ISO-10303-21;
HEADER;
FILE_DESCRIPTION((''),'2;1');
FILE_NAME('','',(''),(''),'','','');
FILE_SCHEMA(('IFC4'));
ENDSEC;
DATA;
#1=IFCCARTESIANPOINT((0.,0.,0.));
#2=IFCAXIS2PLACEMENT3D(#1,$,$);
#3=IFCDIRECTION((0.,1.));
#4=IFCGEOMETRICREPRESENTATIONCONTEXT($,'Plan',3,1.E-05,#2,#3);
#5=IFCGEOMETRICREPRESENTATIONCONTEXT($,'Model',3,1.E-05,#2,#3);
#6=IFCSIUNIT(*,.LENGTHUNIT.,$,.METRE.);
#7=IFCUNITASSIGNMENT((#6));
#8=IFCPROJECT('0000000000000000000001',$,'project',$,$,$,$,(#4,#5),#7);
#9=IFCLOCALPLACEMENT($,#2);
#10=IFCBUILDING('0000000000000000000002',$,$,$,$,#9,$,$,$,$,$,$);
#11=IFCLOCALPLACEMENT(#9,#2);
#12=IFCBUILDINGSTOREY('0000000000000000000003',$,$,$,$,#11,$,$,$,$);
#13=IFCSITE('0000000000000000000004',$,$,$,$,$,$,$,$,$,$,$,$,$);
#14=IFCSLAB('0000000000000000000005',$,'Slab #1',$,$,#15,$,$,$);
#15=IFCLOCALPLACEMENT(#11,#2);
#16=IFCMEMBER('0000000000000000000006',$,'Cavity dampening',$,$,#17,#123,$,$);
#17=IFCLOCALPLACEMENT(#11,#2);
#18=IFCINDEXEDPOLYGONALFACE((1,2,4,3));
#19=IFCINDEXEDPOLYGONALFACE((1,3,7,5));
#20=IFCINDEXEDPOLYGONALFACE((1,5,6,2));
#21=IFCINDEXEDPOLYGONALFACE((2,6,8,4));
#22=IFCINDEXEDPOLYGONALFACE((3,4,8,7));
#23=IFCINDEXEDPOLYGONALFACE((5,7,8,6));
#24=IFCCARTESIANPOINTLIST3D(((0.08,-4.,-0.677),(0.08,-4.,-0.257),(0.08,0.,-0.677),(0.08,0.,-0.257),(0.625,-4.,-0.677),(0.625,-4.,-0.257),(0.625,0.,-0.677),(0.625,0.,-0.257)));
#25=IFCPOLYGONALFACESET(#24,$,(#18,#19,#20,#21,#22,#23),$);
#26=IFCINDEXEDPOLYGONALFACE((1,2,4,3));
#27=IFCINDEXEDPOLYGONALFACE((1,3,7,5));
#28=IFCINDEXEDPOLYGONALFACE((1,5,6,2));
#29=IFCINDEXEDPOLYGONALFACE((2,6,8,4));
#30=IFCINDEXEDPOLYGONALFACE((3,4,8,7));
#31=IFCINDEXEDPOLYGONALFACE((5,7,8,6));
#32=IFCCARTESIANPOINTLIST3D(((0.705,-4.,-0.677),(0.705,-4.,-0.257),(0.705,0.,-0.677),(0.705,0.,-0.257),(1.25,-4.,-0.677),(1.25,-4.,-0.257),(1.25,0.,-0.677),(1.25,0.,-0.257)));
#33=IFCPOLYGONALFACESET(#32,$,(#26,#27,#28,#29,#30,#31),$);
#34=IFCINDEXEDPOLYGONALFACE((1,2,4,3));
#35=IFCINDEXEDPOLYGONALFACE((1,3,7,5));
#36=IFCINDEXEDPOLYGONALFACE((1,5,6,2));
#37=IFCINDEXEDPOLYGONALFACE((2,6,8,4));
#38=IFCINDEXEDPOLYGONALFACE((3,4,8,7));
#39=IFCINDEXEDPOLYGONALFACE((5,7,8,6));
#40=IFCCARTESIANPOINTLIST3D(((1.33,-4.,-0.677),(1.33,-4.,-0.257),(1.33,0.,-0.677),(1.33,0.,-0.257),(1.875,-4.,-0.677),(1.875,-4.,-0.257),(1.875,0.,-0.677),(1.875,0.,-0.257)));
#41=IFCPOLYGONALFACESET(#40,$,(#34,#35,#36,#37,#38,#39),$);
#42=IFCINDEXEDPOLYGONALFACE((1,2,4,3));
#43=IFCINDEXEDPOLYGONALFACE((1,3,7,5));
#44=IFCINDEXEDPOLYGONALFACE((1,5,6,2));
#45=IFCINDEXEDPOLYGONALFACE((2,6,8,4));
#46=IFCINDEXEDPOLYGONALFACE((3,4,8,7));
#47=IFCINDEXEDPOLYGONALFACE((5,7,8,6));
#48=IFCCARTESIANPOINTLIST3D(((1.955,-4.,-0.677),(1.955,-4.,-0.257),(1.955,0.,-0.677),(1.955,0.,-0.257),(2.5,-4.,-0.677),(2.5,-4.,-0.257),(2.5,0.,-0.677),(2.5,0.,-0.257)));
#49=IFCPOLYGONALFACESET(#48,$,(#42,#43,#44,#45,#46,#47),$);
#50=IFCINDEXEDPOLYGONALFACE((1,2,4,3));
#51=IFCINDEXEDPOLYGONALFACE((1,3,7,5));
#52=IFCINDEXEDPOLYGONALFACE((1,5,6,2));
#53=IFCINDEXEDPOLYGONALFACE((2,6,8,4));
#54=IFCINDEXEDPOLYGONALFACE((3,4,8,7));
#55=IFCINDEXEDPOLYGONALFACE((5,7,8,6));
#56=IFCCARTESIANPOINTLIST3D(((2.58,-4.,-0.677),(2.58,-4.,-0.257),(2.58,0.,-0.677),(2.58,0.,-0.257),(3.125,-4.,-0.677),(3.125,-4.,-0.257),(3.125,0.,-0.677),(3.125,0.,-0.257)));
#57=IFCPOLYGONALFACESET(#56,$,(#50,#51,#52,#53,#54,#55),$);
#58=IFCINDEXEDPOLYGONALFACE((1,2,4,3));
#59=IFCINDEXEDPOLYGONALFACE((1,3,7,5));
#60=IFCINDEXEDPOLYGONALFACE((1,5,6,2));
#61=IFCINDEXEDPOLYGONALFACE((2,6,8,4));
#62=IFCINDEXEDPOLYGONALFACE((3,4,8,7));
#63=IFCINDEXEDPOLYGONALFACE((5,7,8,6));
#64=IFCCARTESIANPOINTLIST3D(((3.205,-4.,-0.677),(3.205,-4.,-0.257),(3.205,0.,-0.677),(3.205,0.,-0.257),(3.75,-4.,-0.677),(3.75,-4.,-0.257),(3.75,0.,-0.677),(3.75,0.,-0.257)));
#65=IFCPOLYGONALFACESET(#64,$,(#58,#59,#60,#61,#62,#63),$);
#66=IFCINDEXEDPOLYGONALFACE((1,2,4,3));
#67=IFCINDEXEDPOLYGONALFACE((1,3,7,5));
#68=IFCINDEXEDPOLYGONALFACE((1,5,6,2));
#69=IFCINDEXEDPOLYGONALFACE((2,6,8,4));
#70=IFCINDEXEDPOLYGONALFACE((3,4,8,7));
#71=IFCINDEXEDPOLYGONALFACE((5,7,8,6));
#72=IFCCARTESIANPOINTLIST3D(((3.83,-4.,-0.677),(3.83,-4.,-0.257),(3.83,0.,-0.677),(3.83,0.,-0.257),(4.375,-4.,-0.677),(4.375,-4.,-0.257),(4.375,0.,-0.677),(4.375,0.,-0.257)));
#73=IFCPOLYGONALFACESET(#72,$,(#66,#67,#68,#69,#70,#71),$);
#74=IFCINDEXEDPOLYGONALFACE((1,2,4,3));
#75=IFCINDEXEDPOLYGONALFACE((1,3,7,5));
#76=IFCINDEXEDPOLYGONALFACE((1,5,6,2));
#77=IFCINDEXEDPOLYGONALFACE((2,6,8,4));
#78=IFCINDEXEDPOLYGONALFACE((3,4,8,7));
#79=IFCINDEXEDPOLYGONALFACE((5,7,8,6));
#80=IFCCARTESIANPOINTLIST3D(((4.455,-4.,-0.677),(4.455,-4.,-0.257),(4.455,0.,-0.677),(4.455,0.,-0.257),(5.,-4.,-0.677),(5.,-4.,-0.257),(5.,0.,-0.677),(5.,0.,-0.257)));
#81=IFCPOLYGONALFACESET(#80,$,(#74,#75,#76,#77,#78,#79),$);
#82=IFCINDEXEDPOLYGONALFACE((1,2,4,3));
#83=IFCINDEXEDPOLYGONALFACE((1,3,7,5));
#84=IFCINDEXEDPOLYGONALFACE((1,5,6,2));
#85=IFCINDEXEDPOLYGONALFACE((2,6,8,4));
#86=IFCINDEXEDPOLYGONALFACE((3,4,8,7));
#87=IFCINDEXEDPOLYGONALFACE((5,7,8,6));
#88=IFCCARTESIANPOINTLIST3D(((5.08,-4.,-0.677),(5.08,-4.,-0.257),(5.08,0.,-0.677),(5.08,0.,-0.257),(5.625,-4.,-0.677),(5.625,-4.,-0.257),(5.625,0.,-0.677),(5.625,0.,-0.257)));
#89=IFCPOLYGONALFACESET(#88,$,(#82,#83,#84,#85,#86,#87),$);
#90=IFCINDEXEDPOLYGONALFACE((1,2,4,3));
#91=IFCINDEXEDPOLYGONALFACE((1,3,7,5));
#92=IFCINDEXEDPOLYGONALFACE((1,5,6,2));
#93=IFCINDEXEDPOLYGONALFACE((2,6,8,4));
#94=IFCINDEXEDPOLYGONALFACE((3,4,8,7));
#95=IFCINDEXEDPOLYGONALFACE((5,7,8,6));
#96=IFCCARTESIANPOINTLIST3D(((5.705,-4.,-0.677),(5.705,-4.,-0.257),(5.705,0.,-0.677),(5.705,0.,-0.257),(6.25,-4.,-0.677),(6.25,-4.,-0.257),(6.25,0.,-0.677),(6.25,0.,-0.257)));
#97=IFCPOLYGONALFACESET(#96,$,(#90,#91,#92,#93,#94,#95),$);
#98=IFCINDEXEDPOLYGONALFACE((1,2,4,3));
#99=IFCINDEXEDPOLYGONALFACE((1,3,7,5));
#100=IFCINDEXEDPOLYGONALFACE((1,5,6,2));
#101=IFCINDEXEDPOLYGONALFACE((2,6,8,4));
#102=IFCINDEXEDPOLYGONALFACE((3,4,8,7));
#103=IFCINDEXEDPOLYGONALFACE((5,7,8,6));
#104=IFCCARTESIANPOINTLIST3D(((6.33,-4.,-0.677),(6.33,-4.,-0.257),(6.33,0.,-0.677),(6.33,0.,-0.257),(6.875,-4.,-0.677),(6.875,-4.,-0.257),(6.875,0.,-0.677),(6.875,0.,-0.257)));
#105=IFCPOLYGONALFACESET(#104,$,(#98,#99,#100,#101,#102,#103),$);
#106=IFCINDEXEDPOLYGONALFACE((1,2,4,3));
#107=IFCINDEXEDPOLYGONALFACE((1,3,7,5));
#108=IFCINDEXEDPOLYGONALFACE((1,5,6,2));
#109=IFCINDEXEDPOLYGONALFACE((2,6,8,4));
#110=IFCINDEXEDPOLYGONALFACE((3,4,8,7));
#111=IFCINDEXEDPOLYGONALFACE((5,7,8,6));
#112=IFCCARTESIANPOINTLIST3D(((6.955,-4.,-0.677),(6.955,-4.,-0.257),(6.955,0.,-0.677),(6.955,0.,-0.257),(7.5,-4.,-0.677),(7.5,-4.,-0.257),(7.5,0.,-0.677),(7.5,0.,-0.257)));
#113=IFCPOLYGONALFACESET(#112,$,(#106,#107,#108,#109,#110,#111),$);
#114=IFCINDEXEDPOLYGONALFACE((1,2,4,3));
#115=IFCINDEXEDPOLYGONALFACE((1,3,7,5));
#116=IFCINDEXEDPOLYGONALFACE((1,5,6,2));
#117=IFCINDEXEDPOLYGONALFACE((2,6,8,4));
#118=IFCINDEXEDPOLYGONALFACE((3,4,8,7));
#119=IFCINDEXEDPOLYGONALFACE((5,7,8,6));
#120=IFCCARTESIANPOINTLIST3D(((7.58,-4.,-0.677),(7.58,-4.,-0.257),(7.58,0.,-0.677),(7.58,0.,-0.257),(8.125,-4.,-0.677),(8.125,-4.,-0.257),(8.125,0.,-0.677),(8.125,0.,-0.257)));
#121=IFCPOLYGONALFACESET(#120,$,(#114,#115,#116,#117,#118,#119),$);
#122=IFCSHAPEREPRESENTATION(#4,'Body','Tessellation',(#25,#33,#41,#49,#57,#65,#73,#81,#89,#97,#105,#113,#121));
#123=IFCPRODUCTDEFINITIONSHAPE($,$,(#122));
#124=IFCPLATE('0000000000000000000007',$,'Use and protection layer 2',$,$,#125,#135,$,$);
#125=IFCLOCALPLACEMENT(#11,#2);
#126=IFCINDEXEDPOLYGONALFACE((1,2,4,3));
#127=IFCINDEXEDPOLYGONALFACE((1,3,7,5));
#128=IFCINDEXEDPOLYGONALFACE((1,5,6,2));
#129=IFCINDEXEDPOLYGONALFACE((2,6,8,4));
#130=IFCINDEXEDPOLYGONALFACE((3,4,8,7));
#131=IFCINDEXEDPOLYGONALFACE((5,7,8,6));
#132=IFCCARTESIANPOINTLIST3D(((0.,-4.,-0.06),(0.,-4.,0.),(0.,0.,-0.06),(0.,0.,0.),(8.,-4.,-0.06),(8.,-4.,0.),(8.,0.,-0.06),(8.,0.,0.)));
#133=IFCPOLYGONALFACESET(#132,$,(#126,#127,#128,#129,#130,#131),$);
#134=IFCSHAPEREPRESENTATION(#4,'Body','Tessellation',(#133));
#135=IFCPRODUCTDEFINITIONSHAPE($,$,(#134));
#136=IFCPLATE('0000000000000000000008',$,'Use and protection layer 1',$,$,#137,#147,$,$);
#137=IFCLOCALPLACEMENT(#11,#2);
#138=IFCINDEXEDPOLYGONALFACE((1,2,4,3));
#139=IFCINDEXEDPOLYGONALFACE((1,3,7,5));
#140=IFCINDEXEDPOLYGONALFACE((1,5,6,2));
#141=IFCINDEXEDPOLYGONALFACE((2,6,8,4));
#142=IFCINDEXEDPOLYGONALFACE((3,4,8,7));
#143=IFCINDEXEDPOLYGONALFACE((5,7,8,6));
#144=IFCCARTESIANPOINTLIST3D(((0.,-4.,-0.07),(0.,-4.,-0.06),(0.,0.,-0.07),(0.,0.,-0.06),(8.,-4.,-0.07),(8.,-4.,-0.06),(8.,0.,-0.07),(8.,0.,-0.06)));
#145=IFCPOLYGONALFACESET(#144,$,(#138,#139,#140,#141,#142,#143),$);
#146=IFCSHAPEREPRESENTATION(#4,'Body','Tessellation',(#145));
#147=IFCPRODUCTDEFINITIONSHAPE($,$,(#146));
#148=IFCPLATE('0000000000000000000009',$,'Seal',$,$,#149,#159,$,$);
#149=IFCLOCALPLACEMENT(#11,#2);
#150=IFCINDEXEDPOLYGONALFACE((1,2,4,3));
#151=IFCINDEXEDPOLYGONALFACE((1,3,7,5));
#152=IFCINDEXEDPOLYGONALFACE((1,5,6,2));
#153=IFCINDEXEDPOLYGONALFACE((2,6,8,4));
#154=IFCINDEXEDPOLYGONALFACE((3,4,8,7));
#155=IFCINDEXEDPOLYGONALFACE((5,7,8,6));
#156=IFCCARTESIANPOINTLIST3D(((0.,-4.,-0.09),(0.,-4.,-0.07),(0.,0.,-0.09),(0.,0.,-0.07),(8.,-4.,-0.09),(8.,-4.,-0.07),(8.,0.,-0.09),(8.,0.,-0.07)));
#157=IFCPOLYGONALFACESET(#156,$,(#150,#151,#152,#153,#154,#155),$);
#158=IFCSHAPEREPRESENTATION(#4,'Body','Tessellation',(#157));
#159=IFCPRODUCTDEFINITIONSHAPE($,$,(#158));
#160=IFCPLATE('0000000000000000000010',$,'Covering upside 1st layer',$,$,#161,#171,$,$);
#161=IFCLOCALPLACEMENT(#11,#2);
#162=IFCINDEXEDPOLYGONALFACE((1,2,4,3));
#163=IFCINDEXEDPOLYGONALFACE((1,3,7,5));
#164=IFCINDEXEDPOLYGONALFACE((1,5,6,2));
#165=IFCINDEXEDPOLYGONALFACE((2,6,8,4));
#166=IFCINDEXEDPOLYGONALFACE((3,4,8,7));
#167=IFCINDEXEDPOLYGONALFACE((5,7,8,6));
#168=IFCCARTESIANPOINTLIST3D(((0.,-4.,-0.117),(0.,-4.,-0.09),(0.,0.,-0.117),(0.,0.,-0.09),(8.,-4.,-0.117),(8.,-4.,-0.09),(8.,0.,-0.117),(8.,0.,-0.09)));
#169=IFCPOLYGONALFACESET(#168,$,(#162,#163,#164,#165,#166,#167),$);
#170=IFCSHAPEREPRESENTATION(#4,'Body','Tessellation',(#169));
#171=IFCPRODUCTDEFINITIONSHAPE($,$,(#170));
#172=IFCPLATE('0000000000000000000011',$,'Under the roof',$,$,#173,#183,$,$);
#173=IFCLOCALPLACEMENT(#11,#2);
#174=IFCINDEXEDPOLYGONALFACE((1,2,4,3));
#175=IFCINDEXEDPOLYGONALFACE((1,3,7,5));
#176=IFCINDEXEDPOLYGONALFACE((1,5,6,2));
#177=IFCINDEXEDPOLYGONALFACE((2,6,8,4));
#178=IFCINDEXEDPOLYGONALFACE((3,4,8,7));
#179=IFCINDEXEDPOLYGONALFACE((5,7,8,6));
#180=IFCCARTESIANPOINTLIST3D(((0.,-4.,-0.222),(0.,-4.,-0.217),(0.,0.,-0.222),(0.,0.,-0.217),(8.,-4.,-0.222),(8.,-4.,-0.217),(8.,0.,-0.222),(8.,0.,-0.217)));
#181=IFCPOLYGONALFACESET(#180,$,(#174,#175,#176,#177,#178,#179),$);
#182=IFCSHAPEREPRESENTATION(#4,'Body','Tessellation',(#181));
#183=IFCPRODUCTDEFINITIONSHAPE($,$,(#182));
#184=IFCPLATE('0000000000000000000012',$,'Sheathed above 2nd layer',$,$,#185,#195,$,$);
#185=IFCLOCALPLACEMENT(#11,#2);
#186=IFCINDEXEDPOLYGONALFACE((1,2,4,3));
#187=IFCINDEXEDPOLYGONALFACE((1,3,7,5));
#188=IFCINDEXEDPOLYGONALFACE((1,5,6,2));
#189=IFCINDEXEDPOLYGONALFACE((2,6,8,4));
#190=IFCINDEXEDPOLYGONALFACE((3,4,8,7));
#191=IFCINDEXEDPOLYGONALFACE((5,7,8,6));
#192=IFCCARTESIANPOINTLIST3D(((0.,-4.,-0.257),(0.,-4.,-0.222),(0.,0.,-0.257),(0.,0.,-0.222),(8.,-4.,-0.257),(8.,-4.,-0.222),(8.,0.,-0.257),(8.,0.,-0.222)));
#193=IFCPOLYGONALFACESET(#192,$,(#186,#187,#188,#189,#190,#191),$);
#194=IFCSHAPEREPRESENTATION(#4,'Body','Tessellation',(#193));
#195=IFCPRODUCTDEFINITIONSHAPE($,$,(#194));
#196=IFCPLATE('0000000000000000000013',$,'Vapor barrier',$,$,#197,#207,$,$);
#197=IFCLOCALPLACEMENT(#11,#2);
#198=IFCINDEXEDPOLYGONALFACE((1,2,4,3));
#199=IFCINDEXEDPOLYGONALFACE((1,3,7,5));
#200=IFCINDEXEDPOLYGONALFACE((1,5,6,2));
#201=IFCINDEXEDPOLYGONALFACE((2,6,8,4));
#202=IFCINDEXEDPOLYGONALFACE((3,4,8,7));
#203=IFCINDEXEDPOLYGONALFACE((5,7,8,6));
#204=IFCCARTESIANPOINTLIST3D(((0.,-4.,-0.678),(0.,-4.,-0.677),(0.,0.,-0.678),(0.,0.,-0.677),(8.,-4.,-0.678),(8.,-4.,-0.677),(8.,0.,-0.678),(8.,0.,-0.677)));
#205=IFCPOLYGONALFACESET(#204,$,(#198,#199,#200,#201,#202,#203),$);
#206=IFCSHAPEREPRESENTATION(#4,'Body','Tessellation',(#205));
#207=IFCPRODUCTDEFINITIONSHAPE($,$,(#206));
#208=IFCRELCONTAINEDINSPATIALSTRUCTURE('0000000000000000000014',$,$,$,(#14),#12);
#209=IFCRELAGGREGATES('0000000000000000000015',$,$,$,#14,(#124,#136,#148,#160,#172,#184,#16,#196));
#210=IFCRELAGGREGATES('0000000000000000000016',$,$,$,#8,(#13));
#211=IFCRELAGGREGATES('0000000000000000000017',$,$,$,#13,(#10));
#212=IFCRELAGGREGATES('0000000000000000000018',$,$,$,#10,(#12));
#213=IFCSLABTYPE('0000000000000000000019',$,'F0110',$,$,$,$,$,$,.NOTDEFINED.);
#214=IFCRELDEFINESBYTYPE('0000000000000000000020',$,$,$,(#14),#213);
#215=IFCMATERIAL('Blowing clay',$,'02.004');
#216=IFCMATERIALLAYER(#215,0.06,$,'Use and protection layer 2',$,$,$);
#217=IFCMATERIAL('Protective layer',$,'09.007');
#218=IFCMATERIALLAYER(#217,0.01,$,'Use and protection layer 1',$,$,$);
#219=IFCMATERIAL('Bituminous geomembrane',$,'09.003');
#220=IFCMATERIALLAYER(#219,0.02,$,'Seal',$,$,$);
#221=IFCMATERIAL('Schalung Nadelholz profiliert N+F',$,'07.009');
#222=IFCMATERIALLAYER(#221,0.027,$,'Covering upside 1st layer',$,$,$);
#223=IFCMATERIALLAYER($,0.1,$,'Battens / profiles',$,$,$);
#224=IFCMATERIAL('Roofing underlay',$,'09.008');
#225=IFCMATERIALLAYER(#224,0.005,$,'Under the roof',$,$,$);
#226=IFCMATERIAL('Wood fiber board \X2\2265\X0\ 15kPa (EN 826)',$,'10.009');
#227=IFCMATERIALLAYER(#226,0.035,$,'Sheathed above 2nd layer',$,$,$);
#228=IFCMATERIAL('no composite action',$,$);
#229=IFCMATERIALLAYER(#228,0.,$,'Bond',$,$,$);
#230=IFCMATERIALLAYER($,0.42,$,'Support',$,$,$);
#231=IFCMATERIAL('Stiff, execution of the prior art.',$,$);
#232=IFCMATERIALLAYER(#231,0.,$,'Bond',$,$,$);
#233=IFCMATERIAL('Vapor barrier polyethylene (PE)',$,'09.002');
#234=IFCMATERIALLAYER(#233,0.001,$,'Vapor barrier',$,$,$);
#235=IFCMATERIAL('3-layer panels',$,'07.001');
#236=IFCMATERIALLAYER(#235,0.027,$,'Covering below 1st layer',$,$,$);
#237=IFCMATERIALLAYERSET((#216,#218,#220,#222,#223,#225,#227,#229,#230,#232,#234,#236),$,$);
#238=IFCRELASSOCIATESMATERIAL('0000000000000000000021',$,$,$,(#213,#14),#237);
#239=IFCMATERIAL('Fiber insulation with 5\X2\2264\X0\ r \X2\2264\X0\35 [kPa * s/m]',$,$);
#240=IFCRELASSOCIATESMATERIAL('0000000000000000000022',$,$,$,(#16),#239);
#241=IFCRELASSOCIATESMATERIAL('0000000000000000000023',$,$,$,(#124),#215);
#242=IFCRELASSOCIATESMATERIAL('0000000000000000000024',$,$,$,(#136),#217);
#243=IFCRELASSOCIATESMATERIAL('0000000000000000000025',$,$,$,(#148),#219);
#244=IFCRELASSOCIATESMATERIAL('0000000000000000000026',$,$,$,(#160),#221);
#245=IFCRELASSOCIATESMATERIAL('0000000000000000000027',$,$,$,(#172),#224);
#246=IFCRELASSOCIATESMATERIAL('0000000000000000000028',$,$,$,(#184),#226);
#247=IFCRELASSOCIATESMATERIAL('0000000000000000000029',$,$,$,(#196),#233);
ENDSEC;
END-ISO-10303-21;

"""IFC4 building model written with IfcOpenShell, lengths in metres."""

from ifc_helpers import new_model, si_unit, direction, frame, frame_2d, origin, origin_with_axes, place, context, project, spatial, rectangle, extrude, material, layer, layer_set, type_object, element, aggregate, save


model = new_model("IFC4")

# Units and contexts
plan_context = context("Plan", 3, precision=1e-05, world=origin(), true_north=direction((0.0, 1.0)))
model_context = context("Model", 3, precision=1e-05, world=origin(), true_north=direction((0.0, 1.0)))
ifc_project = project(units=[si_unit("LENGTHUNIT", "METRE")], contexts=[plan_context, model_context])

# Site, building, storey
site = spatial("IfcSite", under=ifc_project)
building_placement = place(None, origin())
building = spatial("IfcBuilding", under=site, at=building_placement)
storey_placement = place(building_placement, origin())
storey = spatial("IfcBuildingStorey", under=building, at=storey_placement)

# Slab, member, plates
ifc_material_1 = material(Name="Blowing clay", Category="02.004")
ifc_layer_1 = layer(ifc_material_1, 0.06, Name="Use and protection layer 2")
ifc_material_2 = material(Name="Protective layer", Category="09.007")
ifc_layer_2 = layer(ifc_material_2, 0.01, Name="Use and protection layer 1")
ifc_material_3 = material(Name="Bituminous geomembrane", Category="09.003")
ifc_layer_3 = layer(ifc_material_3, 0.02, Name="Seal")
ifc_material_4 = material(Name="Schalung Nadelholz profiliert N+F", Category="07.009")
ifc_layer_4 = layer(ifc_material_4, 0.027, Name="Covering upside 1st layer")
ifc_layer_5 = layer(None, 0.1, Name="Battens / profiles")
ifc_material_5 = material(Name="Roofing underlay", Category="09.008")
ifc_layer_6 = layer(ifc_material_5, 0.005, Name="Under the roof")
ifc_material_6 = material(Name="Wood fiber board ≥ 15kPa (EN 826)", Category="10.009")
ifc_layer_7 = layer(ifc_material_6, 0.035, Name="Sheathed above 2nd layer")
ifc_material_7 = material(Name="no composite action")
ifc_layer_8 = layer(ifc_material_7, 0.0, Name="Bond")
ifc_layer_9 = layer(None, 0.42, Name="Support")
ifc_material_8 = material(Name="Stiff, execution of the prior art.")
ifc_layer_10 = layer(ifc_material_8, 0.0, Name="Bond")
ifc_material_9 = material(Name="Vapor barrier polyethylene (PE)", Category="09.002")
ifc_layer_11 = layer(ifc_material_9, 0.001, Name="Vapor barrier")
ifc_material_10 = material(Name="3-layer panels", Category="07.001")
ifc_layer_12 = layer(ifc_material_10, 0.027, Name="Covering below 1st layer")
ifc_layer_set = layer_set([ifc_layer_1, ifc_layer_2, ifc_layer_3, ifc_layer_4, ifc_layer_5, ifc_layer_6, ifc_layer_7, ifc_layer_8, ifc_layer_9, ifc_layer_10, ifc_layer_11, ifc_layer_12])
slab_type = type_object("IfcSlabType", Name="F0110", PredefinedType="NOTDEFINED", material=ifc_layer_set)
slab_placement = place(None, frame((0.0, 0.0, 0.0), z_axis=(0.0, 0.0, -1.0), x_axis=(1.0, 0.0, 0.0)))
slab = element("IfcSlab", 1, at=slab_placement, inside=storey, type_object=slab_type, material=ifc_layer_set, Name="Slab #1")
ifc_material_11 = material(Name="Fiber insulation with 5≤ r ≤35 [kPa * s/m]")
member_1_placement = place(slab_placement, origin())
member_1 = element("IfcMember", 2, at=member_1_placement, material=ifc_material_11, Name="Cavity dampening", context=plan_context, shape_type="SweptSolid", body=[
    extrude(rectangle(XDim=0.545, YDim=0.42, at=frame_2d((0.2725, 0.21), x_axis=(1.0, 0.0))), frame((0.08, 4.0, 0.257), z_axis=(0.0, -1.0, 0.0), x_axis=(1.0, 0.0, 0.0)), (0.0, 0.0, 1.0), 4.0),
    extrude(rectangle(XDim=0.545, YDim=0.42, at=frame_2d((0.2725, 0.21), x_axis=(1.0, 0.0))), frame((0.705, 4.0, 0.257), z_axis=(0.0, -1.0, 0.0), x_axis=(1.0, 0.0, 0.0)), (0.0, 0.0, 1.0), 4.0),
    extrude(rectangle(XDim=0.545, YDim=0.42, at=frame_2d((0.2725, 0.21), x_axis=(1.0, 0.0))), frame((1.33, 4.0, 0.257), z_axis=(0.0, -1.0, 0.0), x_axis=(1.0, 0.0, 0.0)), (0.0, 0.0, 1.0), 4.0),
    extrude(rectangle(XDim=0.545, YDim=0.42, at=frame_2d((0.2725, 0.21), x_axis=(1.0, 0.0))), frame((1.955, 4.0, 0.257), z_axis=(0.0, -1.0, 0.0), x_axis=(1.0, 0.0, 0.0)), (0.0, 0.0, 1.0), 4.0),
    extrude(rectangle(XDim=0.545, YDim=0.42, at=frame_2d((0.2725, 0.21), x_axis=(1.0, 0.0))), frame((2.58, 4.0, 0.257), z_axis=(0.0, -1.0, 0.0), x_axis=(1.0, 0.0, 0.0)), (0.0, 0.0, 1.0), 4.0),
    extrude(rectangle(XDim=0.545, YDim=0.42, at=frame_2d((0.2725, 0.21), x_axis=(1.0, 0.0))), frame((3.205, 4.0, 0.257), z_axis=(0.0, -1.0, 0.0), x_axis=(1.0, 0.0, 0.0)), (0.0, 0.0, 1.0), 4.0),
    extrude(rectangle(XDim=0.545, YDim=0.42, at=frame_2d((0.2725, 0.21), x_axis=(1.0, 0.0))), frame((3.83, 4.0, 0.257), z_axis=(0.0, -1.0, 0.0), x_axis=(1.0, 0.0, 0.0)), (0.0, 0.0, 1.0), 4.0),
    extrude(rectangle(XDim=0.545, YDim=0.42, at=frame_2d((0.2725, 0.21), x_axis=(1.0, 0.0))), frame((4.455, 4.0, 0.257), z_axis=(0.0, -1.0, 0.0), x_axis=(1.0, 0.0, 0.0)), (0.0, 0.0, 1.0), 4.0),
    extrude(rectangle(XDim=0.545, YDim=0.42, at=frame_2d((0.2725, 0.21), x_axis=(1.0, 0.0))), frame((5.08, 4.0, 0.257), z_axis=(0.0, -1.0, 0.0), x_axis=(1.0, 0.0, 0.0)), (0.0, 0.0, 1.0), 4.0),
    extrude(rectangle(XDim=0.545, YDim=0.42, at=frame_2d((0.2725, 0.21), x_axis=(1.0, 0.0))), frame((5.705, 4.0, 0.257), z_axis=(0.0, -1.0, 0.0), x_axis=(1.0, 0.0, 0.0)), (0.0, 0.0, 1.0), 4.0),
    extrude(rectangle(XDim=0.545, YDim=0.42, at=frame_2d((0.2725, 0.21), x_axis=(1.0, 0.0))), frame((6.33, 4.0, 0.257), z_axis=(0.0, -1.0, 0.0), x_axis=(1.0, 0.0, 0.0)), (0.0, 0.0, 1.0), 4.0),
    extrude(rectangle(XDim=0.545, YDim=0.42, at=frame_2d((0.2725, 0.21), x_axis=(1.0, 0.0))), frame((6.955, 4.0, 0.257), z_axis=(0.0, -1.0, 0.0), x_axis=(1.0, 0.0, 0.0)), (0.0, 0.0, 1.0), 4.0),
    extrude(rectangle(XDim=0.545, YDim=0.42, at=frame_2d((0.2725, 0.21), x_axis=(1.0, 0.0))), frame((7.58, 4.0, 0.257), z_axis=(0.0, -1.0, 0.0), x_axis=(1.0, 0.0, 0.0)), (0.0, 0.0, 1.0), 4.0),
])
plate_1_placement = place(slab_placement, origin())
plate_1 = element("IfcPlate", 3, at=plate_1_placement, material=ifc_material_1, Name="Use and protection layer 2", context=plan_context, shape_type="SweptSolid", body=[
    extrude(rectangle(XDim=8.0, YDim=4.0, at=frame_2d((4.0, 2.0), x_axis=(1.0, 0.0))), origin_with_axes(), (0.0, 0.0, 1.0), 0.06),
])
plate_2_placement = place(slab_placement, origin())
plate_2 = element("IfcPlate", 4, at=plate_2_placement, material=ifc_material_2, Name="Use and protection layer 1", context=plan_context, shape_type="SweptSolid", body=[
    extrude(rectangle(XDim=8.0, YDim=4.0, at=frame_2d((4.0, 2.0), x_axis=(1.0, 0.0))), frame((0.0, 0.0, 0.06), z_axis=(0.0, 0.0, 1.0), x_axis=(1.0, 0.0, 0.0)), (0.0, 0.0, 1.0), 0.01),
])
plate_3_placement = place(slab_placement, origin())
plate_3 = element("IfcPlate", 5, at=plate_3_placement, material=ifc_material_3, Name="Seal", context=plan_context, shape_type="SweptSolid", body=[
    extrude(rectangle(XDim=8.0, YDim=4.0, at=frame_2d((4.0, 2.0), x_axis=(1.0, 0.0))), frame((0.0, 0.0, 0.07), z_axis=(0.0, 0.0, 1.0), x_axis=(1.0, 0.0, 0.0)), (0.0, 0.0, 1.0), 0.02),
])
plate_4_placement = place(slab_placement, origin())
plate_4 = element("IfcPlate", 6, at=plate_4_placement, material=ifc_material_4, Name="Covering upside 1st layer", context=plan_context, shape_type="SweptSolid", body=[
    extrude(rectangle(XDim=8.0, YDim=4.0, at=frame_2d((4.0, 2.0), x_axis=(1.0, 0.0))), frame((0.0, 0.0, 0.09), z_axis=(0.0, 0.0, 1.0), x_axis=(1.0, 0.0, 0.0)), (0.0, 0.0, 1.0), 0.027),
])
plate_5_placement = place(slab_placement, origin())
plate_5 = element("IfcPlate", 7, at=plate_5_placement, material=ifc_material_5, Name="Under the roof", context=plan_context, shape_type="SweptSolid", body=[
    extrude(rectangle(XDim=8.0, YDim=4.0, at=frame_2d((4.0, 2.0), x_axis=(1.0, 0.0))), frame((0.0, 0.0, 0.217), z_axis=(0.0, 0.0, 1.0), x_axis=(1.0, 0.0, 0.0)), (0.0, 0.0, 1.0), 0.005),
])
plate_6_placement = place(slab_placement, origin())
plate_6 = element("IfcPlate", 8, at=plate_6_placement, material=ifc_material_6, Name="Sheathed above 2nd layer", context=plan_context, shape_type="SweptSolid", body=[
    extrude(rectangle(XDim=8.0, YDim=4.0, at=frame_2d((4.0, 2.0), x_axis=(1.0, 0.0))), frame((0.0, 0.0, 0.222), z_axis=(0.0, 0.0, 1.0), x_axis=(1.0, 0.0, 0.0)), (0.0, 0.0, 1.0), 0.035),
])
plate_7_placement = place(slab_placement, origin())
plate_7 = element("IfcPlate", 9, at=plate_7_placement, material=ifc_material_9, Name="Vapor barrier", context=plan_context, shape_type="SweptSolid", body=[
    extrude(rectangle(XDim=8.0, YDim=4.0, at=frame_2d((4.0, 2.0), x_axis=(1.0, 0.0))), frame((0.0, 0.0, 0.677), z_axis=(0.0, 0.0, 1.0), x_axis=(1.0, 0.0, 0.0)), (0.0, 0.0, 1.0), 0.001),
])
aggregate(slab, [plate_1, plate_2, plate_3, plate_4, plate_5, plate_6, member_1, plate_7])

save(model, "model.ifc")
